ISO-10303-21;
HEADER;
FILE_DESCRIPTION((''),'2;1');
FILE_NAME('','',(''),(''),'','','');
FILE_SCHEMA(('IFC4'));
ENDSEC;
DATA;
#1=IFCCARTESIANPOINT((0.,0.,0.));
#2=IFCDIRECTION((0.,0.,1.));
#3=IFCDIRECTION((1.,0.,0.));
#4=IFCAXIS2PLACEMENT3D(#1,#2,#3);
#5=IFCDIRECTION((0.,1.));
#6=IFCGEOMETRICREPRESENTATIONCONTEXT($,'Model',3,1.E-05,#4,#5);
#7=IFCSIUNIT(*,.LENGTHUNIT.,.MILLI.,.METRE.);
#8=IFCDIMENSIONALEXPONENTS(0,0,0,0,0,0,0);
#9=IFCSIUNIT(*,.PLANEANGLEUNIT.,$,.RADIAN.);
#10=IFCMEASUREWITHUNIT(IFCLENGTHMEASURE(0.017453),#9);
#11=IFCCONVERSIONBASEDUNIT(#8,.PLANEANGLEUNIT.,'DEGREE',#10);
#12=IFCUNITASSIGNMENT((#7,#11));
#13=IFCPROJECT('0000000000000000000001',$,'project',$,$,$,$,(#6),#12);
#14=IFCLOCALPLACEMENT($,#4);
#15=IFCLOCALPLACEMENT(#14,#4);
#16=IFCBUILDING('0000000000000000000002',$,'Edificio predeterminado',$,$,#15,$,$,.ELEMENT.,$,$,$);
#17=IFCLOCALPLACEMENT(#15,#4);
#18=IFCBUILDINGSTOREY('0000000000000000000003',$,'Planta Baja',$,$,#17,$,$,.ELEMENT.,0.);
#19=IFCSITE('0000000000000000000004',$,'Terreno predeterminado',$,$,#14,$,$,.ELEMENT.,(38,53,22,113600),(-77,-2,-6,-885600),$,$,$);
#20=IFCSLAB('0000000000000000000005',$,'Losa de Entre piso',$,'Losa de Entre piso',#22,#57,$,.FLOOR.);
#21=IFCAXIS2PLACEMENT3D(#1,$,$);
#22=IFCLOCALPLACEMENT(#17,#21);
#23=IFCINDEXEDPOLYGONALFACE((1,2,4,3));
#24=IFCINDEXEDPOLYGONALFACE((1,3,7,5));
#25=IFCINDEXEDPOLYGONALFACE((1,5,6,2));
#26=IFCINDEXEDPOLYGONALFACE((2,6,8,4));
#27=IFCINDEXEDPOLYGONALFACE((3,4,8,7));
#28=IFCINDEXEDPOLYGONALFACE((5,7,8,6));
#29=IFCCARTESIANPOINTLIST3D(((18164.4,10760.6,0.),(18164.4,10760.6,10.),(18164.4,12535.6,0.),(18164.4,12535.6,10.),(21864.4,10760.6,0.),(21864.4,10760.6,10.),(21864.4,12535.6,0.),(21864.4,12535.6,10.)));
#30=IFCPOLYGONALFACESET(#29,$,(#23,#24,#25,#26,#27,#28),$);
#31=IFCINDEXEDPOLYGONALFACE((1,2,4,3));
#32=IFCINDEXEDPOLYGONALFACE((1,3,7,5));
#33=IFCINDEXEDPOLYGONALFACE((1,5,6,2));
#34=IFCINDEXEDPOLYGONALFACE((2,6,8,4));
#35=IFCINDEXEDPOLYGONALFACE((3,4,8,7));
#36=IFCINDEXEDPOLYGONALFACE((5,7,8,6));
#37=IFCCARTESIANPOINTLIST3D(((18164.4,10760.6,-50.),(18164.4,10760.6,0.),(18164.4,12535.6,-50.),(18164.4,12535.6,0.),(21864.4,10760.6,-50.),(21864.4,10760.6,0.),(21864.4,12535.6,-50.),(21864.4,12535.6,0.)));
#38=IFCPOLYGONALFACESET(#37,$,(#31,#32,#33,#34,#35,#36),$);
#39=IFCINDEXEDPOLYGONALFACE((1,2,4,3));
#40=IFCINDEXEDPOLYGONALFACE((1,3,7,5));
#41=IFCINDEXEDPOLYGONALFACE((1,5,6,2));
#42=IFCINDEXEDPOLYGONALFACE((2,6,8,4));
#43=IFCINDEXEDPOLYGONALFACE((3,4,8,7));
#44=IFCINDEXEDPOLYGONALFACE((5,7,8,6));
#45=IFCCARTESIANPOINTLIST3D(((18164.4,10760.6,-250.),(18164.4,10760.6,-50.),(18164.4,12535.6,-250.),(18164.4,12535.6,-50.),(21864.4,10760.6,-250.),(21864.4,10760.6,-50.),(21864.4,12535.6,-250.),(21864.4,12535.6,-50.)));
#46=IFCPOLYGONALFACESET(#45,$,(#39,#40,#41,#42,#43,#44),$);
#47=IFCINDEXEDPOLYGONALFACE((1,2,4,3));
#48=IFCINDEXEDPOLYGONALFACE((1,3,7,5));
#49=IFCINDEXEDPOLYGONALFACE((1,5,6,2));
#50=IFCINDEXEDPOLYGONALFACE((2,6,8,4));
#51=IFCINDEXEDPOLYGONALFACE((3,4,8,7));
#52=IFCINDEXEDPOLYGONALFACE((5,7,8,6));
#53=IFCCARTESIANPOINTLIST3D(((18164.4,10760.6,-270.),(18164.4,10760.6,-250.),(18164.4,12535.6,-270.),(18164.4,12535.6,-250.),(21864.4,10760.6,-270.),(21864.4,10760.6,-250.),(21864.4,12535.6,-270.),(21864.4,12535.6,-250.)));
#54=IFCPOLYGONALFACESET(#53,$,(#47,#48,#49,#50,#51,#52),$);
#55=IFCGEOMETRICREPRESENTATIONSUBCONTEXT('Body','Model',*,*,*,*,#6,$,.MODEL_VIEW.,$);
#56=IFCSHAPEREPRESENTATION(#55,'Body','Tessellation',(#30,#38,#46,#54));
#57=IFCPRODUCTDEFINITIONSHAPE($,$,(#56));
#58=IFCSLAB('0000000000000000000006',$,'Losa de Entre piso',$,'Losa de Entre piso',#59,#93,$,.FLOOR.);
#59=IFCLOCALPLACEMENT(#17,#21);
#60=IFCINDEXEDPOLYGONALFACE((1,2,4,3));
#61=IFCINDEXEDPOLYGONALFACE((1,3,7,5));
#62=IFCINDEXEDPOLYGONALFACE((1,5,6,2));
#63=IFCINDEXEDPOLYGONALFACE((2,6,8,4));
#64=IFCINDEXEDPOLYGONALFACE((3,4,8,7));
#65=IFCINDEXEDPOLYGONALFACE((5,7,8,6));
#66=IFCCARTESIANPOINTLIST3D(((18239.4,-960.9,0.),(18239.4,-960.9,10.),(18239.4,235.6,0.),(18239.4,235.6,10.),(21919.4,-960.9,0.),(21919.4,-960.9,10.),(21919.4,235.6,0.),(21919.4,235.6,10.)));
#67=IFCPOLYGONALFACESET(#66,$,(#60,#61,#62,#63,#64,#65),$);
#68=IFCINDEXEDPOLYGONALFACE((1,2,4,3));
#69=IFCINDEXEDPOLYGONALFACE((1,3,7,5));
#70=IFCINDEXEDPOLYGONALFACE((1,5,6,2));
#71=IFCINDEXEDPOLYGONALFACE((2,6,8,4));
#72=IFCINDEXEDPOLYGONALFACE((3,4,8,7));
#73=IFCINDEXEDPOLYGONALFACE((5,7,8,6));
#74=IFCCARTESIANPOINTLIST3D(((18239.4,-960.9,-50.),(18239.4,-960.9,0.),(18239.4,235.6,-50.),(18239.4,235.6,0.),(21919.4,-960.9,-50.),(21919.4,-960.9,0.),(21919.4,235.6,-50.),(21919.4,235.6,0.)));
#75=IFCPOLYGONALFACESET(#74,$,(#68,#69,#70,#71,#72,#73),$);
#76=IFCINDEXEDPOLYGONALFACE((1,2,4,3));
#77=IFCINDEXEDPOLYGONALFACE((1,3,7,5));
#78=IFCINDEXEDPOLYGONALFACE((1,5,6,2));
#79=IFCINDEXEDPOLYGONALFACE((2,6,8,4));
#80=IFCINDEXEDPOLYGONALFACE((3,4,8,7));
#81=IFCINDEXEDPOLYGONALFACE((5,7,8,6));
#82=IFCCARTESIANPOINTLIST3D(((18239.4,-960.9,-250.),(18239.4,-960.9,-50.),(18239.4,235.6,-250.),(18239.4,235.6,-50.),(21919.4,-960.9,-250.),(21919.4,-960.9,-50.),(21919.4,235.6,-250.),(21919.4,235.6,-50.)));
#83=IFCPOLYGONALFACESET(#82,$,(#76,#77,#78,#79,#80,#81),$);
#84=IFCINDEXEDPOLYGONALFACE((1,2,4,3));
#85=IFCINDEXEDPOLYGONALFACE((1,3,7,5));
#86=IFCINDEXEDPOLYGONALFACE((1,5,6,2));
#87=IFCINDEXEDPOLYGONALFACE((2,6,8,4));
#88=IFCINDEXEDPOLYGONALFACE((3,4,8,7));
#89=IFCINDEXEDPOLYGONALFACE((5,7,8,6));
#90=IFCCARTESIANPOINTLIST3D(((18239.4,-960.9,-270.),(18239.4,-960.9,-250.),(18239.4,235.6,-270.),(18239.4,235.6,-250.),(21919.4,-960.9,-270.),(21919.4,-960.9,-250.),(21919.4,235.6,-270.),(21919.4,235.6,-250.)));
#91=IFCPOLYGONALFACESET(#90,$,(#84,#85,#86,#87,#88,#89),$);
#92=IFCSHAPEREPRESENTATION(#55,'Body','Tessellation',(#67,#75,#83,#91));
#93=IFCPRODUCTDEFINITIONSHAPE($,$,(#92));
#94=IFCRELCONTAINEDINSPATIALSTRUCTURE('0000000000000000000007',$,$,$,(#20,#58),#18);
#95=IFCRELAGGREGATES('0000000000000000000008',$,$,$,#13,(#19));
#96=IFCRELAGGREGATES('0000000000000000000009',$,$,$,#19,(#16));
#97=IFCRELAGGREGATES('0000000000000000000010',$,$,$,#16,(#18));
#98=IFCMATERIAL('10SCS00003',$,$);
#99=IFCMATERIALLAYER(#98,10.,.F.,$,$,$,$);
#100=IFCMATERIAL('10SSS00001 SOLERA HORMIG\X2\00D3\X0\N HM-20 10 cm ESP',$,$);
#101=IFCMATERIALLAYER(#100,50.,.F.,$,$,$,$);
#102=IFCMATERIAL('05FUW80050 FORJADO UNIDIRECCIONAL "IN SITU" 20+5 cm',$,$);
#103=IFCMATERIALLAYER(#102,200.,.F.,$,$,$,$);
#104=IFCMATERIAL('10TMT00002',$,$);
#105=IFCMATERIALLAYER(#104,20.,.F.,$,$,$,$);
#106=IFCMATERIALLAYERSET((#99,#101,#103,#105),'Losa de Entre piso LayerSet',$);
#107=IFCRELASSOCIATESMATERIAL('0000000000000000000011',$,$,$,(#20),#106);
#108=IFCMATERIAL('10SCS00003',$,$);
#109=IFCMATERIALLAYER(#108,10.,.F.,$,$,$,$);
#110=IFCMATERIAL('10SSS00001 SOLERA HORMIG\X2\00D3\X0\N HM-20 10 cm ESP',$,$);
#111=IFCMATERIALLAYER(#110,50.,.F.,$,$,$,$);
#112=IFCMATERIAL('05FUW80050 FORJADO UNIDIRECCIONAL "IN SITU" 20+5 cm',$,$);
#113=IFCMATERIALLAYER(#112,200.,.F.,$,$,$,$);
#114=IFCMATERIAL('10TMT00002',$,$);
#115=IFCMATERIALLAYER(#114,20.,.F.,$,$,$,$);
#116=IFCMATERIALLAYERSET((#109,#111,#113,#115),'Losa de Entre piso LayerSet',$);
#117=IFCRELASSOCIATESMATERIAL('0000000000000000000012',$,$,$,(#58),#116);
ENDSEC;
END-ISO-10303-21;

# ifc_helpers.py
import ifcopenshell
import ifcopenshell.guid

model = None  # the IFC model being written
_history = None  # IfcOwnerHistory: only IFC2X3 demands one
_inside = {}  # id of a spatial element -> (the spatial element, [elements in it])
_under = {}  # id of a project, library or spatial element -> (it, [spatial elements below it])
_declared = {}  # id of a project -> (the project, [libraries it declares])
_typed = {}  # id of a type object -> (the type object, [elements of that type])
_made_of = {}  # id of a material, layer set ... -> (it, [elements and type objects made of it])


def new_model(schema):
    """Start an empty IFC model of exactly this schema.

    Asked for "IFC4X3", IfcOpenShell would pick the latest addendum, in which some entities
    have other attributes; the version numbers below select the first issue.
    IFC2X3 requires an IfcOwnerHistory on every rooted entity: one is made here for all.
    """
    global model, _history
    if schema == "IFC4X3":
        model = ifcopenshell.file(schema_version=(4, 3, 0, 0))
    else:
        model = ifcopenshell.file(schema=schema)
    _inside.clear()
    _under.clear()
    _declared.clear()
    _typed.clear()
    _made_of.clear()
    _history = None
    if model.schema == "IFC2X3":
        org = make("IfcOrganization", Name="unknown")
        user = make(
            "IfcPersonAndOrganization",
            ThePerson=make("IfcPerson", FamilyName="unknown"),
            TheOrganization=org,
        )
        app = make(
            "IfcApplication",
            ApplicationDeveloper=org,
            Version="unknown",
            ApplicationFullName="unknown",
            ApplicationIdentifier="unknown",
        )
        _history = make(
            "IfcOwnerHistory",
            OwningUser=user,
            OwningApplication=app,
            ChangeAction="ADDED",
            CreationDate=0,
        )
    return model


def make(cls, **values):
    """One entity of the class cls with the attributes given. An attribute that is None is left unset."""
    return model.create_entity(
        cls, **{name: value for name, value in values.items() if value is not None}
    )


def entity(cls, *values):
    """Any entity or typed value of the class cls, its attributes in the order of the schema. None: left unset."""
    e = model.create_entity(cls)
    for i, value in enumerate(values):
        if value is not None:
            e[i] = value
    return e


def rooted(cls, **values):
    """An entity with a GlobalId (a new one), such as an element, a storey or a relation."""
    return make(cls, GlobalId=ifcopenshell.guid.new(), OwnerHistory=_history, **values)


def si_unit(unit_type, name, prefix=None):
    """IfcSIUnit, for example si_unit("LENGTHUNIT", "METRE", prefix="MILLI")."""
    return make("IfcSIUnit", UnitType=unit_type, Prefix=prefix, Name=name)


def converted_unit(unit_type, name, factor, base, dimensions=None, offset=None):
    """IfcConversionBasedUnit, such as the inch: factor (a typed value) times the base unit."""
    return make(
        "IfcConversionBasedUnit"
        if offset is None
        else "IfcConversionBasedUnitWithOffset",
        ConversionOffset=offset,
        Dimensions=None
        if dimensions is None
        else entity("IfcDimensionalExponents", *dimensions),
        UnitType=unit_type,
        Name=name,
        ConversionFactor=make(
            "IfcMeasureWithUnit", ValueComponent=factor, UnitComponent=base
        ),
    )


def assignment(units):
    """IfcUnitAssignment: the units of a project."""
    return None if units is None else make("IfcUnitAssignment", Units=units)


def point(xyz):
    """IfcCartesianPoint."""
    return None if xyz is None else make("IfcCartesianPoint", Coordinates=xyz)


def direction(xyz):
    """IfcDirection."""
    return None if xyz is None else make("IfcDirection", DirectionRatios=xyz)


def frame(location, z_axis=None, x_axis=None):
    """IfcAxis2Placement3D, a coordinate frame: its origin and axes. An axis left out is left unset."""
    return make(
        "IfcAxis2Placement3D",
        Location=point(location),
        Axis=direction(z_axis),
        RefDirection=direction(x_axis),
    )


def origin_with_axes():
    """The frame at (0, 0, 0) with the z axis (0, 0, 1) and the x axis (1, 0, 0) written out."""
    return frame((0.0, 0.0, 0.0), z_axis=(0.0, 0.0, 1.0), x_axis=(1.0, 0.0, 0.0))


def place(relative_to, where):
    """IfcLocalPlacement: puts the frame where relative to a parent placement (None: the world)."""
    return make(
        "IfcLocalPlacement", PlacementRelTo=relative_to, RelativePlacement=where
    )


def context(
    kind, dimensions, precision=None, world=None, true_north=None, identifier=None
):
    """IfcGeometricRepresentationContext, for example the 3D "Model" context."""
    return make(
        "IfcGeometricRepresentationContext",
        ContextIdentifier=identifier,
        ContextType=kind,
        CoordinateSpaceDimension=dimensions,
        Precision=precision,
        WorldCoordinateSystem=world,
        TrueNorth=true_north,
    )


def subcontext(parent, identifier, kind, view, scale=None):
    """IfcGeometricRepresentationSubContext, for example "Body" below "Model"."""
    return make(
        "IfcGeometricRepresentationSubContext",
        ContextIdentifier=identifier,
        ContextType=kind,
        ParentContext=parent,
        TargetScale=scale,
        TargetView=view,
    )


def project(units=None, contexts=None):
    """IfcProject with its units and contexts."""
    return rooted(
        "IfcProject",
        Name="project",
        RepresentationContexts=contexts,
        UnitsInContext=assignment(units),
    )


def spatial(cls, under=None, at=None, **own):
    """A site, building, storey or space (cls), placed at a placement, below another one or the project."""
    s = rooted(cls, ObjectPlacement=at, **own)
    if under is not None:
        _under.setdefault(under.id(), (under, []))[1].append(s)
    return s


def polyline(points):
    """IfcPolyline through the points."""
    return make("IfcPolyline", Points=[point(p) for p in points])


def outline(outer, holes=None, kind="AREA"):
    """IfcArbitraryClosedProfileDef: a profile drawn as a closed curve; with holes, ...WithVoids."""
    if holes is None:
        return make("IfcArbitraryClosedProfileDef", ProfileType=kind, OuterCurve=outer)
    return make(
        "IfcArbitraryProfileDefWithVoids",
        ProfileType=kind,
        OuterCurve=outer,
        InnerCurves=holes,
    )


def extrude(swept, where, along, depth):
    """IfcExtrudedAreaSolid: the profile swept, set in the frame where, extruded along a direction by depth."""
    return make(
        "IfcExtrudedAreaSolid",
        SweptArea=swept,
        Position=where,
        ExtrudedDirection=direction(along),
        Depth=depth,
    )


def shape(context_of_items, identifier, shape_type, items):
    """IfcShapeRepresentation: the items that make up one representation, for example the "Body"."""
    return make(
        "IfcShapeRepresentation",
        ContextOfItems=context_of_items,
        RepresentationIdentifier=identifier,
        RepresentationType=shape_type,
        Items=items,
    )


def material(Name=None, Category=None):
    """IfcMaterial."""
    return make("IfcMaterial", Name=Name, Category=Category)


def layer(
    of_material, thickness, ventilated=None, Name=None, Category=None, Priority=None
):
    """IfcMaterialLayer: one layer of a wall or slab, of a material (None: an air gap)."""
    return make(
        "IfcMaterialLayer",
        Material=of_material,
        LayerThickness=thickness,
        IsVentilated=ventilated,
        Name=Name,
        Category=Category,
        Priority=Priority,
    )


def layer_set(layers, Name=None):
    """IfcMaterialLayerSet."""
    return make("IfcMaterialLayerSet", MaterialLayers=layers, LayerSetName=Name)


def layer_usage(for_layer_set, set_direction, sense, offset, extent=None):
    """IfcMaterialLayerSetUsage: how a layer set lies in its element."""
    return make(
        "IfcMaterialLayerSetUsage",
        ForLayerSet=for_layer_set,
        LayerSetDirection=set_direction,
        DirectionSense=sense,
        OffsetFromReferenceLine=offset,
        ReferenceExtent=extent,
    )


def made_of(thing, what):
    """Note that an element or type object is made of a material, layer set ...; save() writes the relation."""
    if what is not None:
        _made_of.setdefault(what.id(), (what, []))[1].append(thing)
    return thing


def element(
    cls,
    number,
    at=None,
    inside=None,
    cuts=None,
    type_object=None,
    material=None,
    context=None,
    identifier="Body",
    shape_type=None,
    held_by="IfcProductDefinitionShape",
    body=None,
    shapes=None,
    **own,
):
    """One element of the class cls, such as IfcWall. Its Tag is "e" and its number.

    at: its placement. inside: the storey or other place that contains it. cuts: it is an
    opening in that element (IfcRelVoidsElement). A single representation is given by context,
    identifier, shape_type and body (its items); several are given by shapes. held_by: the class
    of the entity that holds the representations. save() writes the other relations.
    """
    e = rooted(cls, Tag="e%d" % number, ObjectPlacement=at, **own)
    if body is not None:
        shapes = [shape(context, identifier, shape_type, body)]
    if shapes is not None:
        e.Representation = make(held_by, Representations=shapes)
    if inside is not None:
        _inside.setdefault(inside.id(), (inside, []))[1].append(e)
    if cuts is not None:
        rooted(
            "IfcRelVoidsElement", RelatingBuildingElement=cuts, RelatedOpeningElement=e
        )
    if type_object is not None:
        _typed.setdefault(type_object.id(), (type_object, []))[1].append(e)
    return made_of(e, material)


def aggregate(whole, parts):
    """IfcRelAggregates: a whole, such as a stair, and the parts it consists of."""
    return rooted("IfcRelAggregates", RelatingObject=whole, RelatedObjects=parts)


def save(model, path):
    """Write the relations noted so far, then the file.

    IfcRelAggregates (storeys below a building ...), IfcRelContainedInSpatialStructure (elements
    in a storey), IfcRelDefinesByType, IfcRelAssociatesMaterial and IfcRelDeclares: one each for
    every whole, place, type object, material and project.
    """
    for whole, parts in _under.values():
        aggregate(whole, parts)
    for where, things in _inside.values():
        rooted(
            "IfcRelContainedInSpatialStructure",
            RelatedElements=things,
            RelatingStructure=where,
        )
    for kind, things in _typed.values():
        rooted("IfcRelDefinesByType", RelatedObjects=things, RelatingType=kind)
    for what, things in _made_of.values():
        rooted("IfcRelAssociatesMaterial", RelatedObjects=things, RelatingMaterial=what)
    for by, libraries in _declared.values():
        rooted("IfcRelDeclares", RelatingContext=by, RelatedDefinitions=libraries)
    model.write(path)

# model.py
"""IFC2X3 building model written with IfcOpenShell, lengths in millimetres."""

from ifc_helpers import new_model, entity, si_unit, converted_unit, direction, frame, origin_with_axes, place, context, subcontext, project, spatial, polyline, outline, extrude, material, layer, layer_set, layer_usage, element, save


model = new_model("IFC2X3")

# Units and contexts
model_context = context("Model", 3, precision=1e-05, world=origin_with_axes(), true_north=direction((0.0, 1.0)))
body_context = subcontext(model_context, "Body", "Model", "MODEL_VIEW")
ifc_project = project(units=[si_unit("LENGTHUNIT", "METRE", prefix="MILLI"), converted_unit("PLANEANGLEUNIT", "DEGREE", entity("IfcLengthMeasure", 0.017453), si_unit("PLANEANGLEUNIT", "RADIAN"), dimensions=[0, 0, 0, 0, 0, 0, 0])], contexts=[model_context])

# Site, building, storey
site_placement = place(None, origin_with_axes())
site = spatial("IfcSite", under=ifc_project, at=site_placement, Name="Terreno predeterminado", CompositionType="ELEMENT", RefLatitude=(38, 53, 22, 113600), RefLongitude=(-77, -2, -6, -885600))
building_placement = place(site_placement, origin_with_axes())
building = spatial("IfcBuilding", under=site, at=building_placement, Name="Edificio predeterminado", CompositionType="ELEMENT")
storey_placement = place(building_placement, origin_with_axes())
storey = spatial("IfcBuildingStorey", under=building, at=storey_placement, Name="Planta Baja", CompositionType="ELEMENT", Elevation=0.0)

# Slabs
ifc_material_1 = material(Name="10SCS00003")
ifc_layer_1 = layer(ifc_material_1, 10.0, ventilated=False)
ifc_material_2 = material(Name="10SSS00001 SOLERA HORMIGÓN HM-20 10 cm ESP")
ifc_layer_2 = layer(ifc_material_2, 50.0, ventilated=False)
ifc_material_3 = material(Name="05FUW80050 FORJADO UNIDIRECCIONAL \"IN SITU\" 20+5 cm")
ifc_layer_3 = layer(ifc_material_3, 200.0, ventilated=False)
ifc_material_4 = material(Name="10TMT00002")
ifc_layer_4 = layer(ifc_material_4, 20.0, ventilated=False)
ifc_layer_set_1 = layer_set([ifc_layer_1, ifc_layer_2, ifc_layer_3, ifc_layer_4], Name="Losa de Entre piso LayerSet")
ifc_layer_usage_1 = layer_usage(ifc_layer_set_1, "AXIS3", "POSITIVE", 0.0)
slab_1_placement = place(storey_placement, origin_with_axes())
element("IfcSlab", 1, at=slab_1_placement, inside=storey, material=ifc_layer_usage_1, Name="Losa de Entre piso", ObjectType="Losa de Entre piso", PredefinedType="FLOOR", context=body_context, shape_type="SweptSolid", body=[
    extrude(outline(polyline([(0.0, 0.0), (1775.0, 0.0), (1775.0, 3700.0), (0.0, 3700.0), (0.0, 0.0)])), frame((21864.4, 12535.6, 0.0), z_axis=(0.0, 0.0, -1.0), x_axis=(0.0, -1.0, 0.0)), (0.0, 0.0, -1.0), 10.0),
    extrude(outline(polyline([(0.0, 0.0), (1775.0, 0.0), (1775.0, 3700.0), (0.0, 3700.0), (0.0, 0.0)])), frame((21864.4, 12535.6, -50.0), z_axis=(0.0, 0.0, -1.0), x_axis=(0.0, -1.0, 0.0)), (0.0, 0.0, -1.0), 50.0),
    extrude(outline(polyline([(0.0, 0.0), (1775.0, 0.0), (1775.0, 3700.0), (0.0, 3700.0), (0.0, 0.0)])), frame((21864.4, 12535.6, -250.0), z_axis=(0.0, 0.0, -1.0), x_axis=(0.0, -1.0, 0.0)), (0.0, 0.0, -1.0), 200.0),
    extrude(outline(polyline([(0.0, 0.0), (1775.0, 0.0), (1775.0, 3700.0), (0.0, 3700.0), (0.0, 0.0)])), frame((21864.4, 12535.6, -270.0), z_axis=(0.0, 0.0, -1.0), x_axis=(0.0, -1.0, 0.0)), (0.0, 0.0, -1.0), 20.0),
])
ifc_material_5 = material(Name="10SCS00003")
ifc_layer_5 = layer(ifc_material_5, 10.0, ventilated=False)
ifc_material_6 = material(Name="10SSS00001 SOLERA HORMIGÓN HM-20 10 cm ESP")
ifc_layer_6 = layer(ifc_material_6, 50.0, ventilated=False)
ifc_material_7 = material(Name="05FUW80050 FORJADO UNIDIRECCIONAL \"IN SITU\" 20+5 cm")
ifc_layer_7 = layer(ifc_material_7, 200.0, ventilated=False)
ifc_material_8 = material(Name="10TMT00002")
ifc_layer_8 = layer(ifc_material_8, 20.0, ventilated=False)
ifc_layer_set_2 = layer_set([ifc_layer_5, ifc_layer_6, ifc_layer_7, ifc_layer_8], Name="Losa de Entre piso LayerSet")
ifc_layer_usage_2 = layer_usage(ifc_layer_set_2, "AXIS3", "POSITIVE", 0.0)
slab_2_placement = place(storey_placement, origin_with_axes())
element("IfcSlab", 2, at=slab_2_placement, inside=storey, material=ifc_layer_usage_2, Name="Losa de Entre piso", ObjectType="Losa de Entre piso", PredefinedType="FLOOR", context=body_context, shape_type="SweptSolid", body=[
    extrude(outline(polyline([(0.0, 0.0), (1196.6, 0.0), (1196.6, 3680.0), (0.0, 3680.0), (0.0, 0.0)])), frame((21919.4, 235.6, 0.0), z_axis=(0.0, 0.0, -1.0), x_axis=(0.0, -1.0, 0.0)), (0.0, 0.0, -1.0), 10.0),
    extrude(outline(polyline([(0.0, 0.0), (1196.6, 0.0), (1196.6, 3680.0), (0.0, 3680.0), (0.0, 0.0)])), frame((21919.4, 235.6, -50.0), z_axis=(0.0, 0.0, -1.0), x_axis=(0.0, -1.0, 0.0)), (0.0, 0.0, -1.0), 50.0),
    extrude(outline(polyline([(0.0, 0.0), (1196.6, 0.0), (1196.6, 3680.0), (0.0, 3680.0), (0.0, 0.0)])), frame((21919.4, 235.6, -250.0), z_axis=(0.0, 0.0, -1.0), x_axis=(0.0, -1.0, 0.0)), (0.0, 0.0, -1.0), 200.0),
    extrude(outline(polyline([(0.0, 0.0), (1196.6, 0.0), (1196.6, 3680.0), (0.0, 3680.0), (0.0, 0.0)])), frame((21919.4, 235.6, -270.0), z_axis=(0.0, 0.0, -1.0), x_axis=(0.0, -1.0, 0.0)), (0.0, 0.0, -1.0), 20.0),
])

save(model, "model.ifc")
